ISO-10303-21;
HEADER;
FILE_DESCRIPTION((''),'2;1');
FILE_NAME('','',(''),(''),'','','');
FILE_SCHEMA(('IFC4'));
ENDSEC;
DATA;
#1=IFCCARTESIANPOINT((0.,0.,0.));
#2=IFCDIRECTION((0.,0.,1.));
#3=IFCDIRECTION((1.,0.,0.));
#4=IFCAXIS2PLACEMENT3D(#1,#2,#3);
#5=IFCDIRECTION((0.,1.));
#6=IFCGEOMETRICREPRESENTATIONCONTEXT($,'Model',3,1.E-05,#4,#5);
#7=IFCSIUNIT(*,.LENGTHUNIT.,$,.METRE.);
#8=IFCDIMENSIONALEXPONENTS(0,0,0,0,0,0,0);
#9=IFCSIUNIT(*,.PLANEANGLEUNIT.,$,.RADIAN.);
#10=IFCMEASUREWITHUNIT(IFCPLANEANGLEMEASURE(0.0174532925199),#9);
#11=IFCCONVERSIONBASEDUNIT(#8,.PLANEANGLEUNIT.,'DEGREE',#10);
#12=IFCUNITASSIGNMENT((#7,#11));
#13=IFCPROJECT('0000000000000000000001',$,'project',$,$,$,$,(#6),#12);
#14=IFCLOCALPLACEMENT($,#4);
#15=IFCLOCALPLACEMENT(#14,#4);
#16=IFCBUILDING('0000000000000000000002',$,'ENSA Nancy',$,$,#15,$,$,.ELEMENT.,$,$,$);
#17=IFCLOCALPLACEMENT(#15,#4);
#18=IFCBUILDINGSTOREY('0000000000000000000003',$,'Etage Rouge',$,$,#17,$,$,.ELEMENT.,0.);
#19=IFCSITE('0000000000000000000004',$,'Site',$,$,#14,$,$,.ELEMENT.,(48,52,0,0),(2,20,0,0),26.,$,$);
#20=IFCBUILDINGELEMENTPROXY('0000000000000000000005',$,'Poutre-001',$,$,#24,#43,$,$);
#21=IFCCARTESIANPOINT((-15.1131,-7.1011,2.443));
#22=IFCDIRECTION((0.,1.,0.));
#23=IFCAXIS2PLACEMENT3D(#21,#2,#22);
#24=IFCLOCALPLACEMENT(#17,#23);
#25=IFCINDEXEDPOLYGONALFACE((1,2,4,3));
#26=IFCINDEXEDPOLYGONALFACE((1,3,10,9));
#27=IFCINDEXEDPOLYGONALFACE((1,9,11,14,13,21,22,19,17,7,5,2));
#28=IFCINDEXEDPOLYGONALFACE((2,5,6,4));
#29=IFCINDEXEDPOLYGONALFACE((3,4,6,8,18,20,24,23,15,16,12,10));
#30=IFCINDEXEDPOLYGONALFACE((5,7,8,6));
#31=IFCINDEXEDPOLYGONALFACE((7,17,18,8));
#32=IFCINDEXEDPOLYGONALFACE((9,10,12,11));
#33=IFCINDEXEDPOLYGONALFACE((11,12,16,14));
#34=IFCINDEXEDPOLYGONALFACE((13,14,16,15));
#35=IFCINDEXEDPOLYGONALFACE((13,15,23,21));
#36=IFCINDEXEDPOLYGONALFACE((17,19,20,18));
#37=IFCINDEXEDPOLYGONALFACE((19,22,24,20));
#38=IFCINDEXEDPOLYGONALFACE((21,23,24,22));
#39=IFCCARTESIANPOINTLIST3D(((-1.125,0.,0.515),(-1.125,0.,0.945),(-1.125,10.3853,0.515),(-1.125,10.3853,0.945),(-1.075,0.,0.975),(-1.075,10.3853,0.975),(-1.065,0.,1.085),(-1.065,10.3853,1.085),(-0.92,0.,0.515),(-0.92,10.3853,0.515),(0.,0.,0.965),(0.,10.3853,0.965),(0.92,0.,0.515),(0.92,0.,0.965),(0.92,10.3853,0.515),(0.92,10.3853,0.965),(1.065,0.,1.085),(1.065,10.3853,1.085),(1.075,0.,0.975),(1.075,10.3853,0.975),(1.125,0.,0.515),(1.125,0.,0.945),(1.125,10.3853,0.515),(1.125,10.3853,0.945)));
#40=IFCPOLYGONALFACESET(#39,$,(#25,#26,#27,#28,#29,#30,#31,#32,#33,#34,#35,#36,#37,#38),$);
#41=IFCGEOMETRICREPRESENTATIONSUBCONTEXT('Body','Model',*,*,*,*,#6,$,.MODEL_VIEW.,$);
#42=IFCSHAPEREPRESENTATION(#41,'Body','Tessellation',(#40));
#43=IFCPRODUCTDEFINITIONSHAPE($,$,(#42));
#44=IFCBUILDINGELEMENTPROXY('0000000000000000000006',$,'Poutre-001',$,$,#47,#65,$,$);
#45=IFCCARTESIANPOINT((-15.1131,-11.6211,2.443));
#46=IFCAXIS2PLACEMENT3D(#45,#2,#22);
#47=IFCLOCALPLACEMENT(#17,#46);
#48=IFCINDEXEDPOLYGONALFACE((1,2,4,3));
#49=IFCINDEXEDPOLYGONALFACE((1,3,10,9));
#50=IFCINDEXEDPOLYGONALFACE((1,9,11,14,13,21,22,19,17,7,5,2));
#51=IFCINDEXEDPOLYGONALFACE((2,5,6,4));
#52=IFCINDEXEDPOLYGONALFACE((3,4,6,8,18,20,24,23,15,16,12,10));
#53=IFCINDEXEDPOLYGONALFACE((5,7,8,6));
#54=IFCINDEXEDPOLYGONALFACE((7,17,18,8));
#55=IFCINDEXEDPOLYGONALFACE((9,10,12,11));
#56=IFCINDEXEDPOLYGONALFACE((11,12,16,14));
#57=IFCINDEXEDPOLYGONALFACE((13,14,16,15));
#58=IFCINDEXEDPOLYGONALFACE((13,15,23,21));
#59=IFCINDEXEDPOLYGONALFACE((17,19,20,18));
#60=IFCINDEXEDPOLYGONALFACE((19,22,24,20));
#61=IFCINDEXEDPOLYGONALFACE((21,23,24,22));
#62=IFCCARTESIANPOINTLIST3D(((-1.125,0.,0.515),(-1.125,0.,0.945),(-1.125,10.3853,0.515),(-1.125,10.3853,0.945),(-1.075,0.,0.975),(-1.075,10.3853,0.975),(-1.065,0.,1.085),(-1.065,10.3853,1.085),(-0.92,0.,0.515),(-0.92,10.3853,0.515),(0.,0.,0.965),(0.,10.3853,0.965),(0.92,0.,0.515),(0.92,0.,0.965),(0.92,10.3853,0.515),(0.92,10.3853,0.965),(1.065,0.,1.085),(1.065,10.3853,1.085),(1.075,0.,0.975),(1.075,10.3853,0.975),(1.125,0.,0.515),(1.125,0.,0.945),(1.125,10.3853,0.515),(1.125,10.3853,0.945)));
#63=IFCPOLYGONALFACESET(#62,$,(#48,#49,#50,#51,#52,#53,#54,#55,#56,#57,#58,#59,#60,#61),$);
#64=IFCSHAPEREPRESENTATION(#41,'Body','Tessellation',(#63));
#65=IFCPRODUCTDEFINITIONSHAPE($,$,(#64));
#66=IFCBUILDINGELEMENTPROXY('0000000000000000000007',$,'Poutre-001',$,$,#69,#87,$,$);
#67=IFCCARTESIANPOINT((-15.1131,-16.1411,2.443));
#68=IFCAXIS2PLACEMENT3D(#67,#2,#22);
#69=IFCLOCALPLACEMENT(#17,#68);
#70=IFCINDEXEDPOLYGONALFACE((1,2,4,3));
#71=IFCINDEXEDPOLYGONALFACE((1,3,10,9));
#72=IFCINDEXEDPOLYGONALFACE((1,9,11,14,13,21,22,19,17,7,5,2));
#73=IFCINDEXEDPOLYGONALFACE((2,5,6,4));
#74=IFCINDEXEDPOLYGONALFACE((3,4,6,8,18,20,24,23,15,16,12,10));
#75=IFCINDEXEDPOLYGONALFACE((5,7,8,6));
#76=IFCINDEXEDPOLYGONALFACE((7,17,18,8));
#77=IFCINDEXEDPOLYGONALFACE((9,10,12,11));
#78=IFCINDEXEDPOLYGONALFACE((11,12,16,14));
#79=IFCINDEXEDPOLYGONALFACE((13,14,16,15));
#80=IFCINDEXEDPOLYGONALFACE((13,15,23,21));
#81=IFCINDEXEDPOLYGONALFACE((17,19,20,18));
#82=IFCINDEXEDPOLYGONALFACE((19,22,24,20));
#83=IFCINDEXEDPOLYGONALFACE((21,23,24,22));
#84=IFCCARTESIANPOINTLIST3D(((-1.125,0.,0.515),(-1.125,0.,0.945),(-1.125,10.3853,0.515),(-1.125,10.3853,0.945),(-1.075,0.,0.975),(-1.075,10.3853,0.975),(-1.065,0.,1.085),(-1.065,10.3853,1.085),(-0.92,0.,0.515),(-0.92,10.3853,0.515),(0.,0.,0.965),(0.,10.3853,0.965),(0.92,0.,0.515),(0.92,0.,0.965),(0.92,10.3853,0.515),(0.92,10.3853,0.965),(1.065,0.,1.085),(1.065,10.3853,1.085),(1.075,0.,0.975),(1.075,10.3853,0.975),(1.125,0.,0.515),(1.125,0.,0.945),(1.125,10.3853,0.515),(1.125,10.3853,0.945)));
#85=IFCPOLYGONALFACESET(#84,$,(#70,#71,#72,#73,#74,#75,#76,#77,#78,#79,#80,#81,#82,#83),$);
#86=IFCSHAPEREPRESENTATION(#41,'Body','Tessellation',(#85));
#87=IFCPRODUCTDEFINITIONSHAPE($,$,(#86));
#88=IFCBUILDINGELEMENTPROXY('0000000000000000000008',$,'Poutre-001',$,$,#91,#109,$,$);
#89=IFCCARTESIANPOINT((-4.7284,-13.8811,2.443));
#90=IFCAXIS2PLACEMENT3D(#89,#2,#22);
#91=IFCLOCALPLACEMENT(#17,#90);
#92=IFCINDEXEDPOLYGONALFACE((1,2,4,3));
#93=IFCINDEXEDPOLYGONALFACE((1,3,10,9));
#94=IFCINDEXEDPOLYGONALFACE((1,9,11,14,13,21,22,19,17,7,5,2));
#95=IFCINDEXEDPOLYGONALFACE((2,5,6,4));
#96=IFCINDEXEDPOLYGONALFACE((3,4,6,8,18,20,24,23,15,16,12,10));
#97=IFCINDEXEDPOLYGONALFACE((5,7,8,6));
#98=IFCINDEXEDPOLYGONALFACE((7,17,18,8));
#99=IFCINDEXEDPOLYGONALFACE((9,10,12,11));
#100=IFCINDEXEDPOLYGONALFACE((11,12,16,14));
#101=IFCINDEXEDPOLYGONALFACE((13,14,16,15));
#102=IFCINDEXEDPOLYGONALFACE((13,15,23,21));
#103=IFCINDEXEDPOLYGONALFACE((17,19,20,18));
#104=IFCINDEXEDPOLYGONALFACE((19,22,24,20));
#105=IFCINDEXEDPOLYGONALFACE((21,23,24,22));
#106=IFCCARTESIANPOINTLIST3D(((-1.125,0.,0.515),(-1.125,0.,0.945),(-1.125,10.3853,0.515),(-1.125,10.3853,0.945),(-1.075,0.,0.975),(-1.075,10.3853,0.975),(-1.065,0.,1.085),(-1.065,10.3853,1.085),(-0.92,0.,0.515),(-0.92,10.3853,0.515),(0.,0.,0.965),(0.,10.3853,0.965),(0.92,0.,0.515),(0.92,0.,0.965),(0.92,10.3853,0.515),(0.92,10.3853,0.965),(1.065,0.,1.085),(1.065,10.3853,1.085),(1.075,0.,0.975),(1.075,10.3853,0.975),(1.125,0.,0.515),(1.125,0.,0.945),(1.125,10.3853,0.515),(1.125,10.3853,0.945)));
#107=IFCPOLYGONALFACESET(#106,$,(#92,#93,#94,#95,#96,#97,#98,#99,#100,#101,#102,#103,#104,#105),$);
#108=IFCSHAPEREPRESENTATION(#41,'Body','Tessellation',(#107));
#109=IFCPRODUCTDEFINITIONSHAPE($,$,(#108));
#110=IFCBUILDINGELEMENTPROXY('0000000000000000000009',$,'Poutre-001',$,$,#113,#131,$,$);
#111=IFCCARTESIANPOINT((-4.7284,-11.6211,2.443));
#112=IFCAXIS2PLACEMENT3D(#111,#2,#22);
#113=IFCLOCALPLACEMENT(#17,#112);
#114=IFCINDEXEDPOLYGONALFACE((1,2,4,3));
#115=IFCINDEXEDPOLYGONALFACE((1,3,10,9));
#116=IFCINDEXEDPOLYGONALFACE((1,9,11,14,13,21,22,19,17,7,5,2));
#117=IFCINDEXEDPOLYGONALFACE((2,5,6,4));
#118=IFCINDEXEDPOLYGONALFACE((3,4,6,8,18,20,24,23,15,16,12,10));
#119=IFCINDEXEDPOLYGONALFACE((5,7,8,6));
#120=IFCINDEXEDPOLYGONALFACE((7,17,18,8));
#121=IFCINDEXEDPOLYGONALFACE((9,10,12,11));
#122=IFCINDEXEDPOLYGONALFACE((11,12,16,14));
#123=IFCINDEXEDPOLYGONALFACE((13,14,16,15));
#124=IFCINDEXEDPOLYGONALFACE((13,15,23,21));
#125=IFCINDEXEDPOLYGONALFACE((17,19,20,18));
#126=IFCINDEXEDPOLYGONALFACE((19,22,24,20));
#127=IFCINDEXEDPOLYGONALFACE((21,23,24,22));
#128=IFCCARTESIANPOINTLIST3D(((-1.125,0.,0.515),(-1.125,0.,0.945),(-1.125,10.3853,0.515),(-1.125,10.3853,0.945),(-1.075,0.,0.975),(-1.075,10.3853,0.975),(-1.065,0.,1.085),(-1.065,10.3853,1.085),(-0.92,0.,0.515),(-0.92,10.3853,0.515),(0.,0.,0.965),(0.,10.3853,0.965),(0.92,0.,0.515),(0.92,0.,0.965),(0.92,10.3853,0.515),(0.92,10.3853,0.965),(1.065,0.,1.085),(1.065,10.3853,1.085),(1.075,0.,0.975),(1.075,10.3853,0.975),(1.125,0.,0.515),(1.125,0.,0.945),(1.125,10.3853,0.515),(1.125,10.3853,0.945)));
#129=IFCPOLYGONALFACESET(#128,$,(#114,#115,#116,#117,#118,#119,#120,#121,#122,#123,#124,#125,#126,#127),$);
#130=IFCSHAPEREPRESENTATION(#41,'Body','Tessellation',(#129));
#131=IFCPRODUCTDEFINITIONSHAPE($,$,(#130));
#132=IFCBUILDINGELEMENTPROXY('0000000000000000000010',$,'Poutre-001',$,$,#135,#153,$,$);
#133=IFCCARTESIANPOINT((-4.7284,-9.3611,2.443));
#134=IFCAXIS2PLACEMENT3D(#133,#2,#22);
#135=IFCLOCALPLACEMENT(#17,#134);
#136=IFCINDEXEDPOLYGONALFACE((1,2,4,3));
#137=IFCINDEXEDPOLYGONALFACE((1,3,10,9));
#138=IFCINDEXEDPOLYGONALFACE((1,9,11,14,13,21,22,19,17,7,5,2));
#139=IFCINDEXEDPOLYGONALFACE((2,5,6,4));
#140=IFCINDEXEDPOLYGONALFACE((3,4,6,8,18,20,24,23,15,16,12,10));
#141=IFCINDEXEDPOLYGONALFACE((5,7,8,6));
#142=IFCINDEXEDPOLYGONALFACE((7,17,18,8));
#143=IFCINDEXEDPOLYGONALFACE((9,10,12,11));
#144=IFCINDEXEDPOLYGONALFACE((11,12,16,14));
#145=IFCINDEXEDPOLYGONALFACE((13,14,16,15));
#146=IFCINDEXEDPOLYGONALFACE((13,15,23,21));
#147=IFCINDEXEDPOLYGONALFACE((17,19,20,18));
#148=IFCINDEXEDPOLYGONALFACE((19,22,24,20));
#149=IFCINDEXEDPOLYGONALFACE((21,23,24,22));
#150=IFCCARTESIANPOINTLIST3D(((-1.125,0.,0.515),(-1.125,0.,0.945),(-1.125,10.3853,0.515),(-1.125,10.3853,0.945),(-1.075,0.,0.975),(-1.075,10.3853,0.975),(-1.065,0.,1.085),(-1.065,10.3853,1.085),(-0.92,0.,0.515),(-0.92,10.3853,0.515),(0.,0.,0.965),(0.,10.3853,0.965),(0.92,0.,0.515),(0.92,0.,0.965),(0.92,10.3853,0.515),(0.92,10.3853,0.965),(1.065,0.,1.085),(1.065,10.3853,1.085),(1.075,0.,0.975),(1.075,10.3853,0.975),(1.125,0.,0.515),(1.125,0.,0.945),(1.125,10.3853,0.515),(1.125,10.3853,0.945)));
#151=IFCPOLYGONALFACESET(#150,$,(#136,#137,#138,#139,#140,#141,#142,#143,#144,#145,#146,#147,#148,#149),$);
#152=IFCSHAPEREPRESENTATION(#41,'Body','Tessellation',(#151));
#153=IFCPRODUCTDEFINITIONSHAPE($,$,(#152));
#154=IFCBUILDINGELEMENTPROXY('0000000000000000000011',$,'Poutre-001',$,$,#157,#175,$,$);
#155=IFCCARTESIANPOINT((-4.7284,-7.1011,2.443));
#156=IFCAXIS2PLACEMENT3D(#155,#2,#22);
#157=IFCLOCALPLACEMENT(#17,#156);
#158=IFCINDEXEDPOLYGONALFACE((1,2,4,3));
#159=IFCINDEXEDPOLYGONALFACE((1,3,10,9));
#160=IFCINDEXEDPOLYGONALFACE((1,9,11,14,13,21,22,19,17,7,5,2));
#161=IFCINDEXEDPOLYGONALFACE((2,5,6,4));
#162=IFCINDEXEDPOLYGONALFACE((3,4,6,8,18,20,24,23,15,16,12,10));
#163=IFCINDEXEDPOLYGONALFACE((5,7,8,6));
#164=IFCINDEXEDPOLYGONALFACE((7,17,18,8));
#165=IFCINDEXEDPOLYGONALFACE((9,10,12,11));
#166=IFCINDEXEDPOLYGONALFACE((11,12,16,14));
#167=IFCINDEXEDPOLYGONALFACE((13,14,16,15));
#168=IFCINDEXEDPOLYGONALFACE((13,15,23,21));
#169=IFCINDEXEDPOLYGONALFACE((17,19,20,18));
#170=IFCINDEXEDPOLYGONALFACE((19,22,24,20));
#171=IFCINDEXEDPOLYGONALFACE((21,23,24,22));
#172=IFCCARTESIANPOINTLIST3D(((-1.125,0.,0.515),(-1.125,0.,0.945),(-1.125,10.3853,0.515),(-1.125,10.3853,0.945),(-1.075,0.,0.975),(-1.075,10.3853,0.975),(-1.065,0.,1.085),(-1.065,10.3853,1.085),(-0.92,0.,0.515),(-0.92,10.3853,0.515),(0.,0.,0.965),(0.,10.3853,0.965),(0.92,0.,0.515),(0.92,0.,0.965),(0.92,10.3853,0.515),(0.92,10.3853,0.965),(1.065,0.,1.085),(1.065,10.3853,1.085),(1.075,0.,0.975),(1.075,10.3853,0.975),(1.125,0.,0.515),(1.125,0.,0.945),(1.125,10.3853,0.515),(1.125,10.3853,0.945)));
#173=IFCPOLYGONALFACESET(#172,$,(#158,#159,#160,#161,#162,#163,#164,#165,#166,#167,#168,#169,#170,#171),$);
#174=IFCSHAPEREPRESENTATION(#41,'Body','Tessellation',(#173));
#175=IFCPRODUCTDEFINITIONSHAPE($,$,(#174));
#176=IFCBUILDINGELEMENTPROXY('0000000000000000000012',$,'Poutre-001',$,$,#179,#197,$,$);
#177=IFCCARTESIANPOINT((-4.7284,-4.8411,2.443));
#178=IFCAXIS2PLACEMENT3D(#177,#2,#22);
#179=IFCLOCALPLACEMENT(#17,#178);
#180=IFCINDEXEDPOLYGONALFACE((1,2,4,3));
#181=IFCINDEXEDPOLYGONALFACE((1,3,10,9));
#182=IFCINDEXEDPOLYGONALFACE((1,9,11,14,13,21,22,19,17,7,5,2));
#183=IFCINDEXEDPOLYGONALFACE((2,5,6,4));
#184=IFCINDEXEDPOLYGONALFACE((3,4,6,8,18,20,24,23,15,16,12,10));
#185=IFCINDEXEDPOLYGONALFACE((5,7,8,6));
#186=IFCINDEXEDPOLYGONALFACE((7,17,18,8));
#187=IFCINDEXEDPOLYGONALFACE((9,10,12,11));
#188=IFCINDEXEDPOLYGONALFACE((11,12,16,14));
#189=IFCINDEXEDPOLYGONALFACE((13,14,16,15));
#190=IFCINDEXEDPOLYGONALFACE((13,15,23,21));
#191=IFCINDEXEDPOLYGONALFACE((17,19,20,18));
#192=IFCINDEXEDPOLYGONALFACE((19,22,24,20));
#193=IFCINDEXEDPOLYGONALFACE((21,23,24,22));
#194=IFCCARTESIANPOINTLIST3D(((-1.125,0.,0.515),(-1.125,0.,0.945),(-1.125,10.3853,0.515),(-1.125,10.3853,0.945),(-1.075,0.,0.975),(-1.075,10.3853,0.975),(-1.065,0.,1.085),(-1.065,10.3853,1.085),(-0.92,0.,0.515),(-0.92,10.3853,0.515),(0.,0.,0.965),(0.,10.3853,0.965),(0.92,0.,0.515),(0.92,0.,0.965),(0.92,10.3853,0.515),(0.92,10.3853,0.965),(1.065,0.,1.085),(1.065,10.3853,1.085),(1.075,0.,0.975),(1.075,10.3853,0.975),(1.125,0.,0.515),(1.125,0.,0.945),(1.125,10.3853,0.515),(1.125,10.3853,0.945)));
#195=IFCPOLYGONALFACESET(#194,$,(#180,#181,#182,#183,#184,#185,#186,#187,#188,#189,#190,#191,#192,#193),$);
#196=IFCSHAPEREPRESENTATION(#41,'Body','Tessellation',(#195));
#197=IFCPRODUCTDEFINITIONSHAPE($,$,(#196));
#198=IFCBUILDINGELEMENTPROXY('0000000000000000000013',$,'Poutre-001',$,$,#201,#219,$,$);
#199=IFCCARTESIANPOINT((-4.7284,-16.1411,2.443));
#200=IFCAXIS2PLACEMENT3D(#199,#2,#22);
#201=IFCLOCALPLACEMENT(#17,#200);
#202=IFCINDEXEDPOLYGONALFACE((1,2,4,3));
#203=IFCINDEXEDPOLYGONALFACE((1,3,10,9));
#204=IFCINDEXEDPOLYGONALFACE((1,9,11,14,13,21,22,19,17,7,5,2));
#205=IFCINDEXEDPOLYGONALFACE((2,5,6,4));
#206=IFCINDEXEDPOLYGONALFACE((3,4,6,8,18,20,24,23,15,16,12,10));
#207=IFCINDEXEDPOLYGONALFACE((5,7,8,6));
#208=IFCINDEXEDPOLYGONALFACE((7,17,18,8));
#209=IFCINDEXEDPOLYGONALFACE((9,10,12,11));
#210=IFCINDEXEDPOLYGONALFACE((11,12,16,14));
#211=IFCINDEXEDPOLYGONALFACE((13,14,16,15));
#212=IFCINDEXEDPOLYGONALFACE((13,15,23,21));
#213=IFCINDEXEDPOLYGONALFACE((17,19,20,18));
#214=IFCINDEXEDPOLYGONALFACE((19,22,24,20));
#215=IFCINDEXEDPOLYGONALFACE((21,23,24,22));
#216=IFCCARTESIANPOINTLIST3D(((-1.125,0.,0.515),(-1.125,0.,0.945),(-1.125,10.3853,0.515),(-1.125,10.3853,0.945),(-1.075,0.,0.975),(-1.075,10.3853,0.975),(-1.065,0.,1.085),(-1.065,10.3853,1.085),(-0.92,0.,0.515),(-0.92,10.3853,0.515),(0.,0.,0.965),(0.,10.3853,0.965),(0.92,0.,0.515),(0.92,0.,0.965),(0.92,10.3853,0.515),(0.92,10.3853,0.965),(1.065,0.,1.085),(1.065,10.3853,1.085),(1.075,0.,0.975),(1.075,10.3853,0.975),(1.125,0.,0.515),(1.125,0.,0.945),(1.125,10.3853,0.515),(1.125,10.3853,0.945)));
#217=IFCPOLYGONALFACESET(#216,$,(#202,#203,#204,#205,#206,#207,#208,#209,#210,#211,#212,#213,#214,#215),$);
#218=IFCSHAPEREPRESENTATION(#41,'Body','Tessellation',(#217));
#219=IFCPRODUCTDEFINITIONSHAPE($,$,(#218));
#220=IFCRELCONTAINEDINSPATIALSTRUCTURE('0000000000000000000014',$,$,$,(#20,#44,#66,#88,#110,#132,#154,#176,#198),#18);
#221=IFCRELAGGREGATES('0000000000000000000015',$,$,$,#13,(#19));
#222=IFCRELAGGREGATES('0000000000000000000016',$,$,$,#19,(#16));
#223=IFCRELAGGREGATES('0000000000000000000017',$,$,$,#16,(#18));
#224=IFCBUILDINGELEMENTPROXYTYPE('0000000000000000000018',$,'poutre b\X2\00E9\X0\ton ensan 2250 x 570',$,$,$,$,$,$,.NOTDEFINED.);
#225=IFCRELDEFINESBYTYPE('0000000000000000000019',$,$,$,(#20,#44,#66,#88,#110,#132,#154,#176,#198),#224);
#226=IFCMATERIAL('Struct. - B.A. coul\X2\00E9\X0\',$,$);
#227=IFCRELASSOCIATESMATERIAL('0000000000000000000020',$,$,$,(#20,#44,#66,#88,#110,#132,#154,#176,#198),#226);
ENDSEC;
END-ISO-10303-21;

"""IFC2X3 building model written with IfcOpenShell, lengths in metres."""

from ifc_helpers import new_model, entity, si_unit, converted_unit, direction, frame, origin_with_axes, place, context, subcontext, project, spatial, polyline, outline, extrude, material, type_object, element, save


model = new_model("IFC2X3")

# Units and contexts
model_context = context("Model", 3, precision=1e-05, world=origin_with_axes(), true_north=direction((0.0, 1.0)))
body_context = subcontext(model_context, "Body", "Model", "MODEL_VIEW")
ifc_project = project(units=[si_unit("LENGTHUNIT", "METRE"), converted_unit("PLANEANGLEUNIT", "DEGREE", entity("IfcPlaneAngleMeasure", 0.0174532925199), si_unit("PLANEANGLEUNIT", "RADIAN"), dimensions=[0, 0, 0, 0, 0, 0, 0])], contexts=[model_context])

# Site, building, storey
site_placement = place(None, origin_with_axes())
site = spatial("IfcSite", under=ifc_project, at=site_placement, Name="Site", CompositionType="ELEMENT", RefLatitude=(48, 52, 0, 0), RefLongitude=(2, 20, 0, 0), RefElevation=26.0)
building_placement = place(site_placement, origin_with_axes())
building = spatial("IfcBuilding", under=site, at=building_placement, Name="ENSA Nancy", CompositionType="ELEMENT")
storey_placement = place(building_placement, origin_with_axes())
storey = spatial("IfcBuildingStorey", under=building, at=storey_placement, Name="Etage Rouge", CompositionType="ELEMENT", Elevation=0.0)

# Building element proxies
ifc_material_1 = material(Name="Struct. - B.A. coulé")
building_element_proxy_type_1 = type_object("IfcBuildingElementProxyType", Name="poutre béton ensan 2250 x 570", PredefinedType="NOTDEFINED")
for number, where, z_axis, x_axis, name in (
    (1, (-15.1131, -7.1011, 2.443), (0.0, 0.0, 1.0), (0.0, 1.0, 0.0), "Poutre-001"),
    (2, (-15.1131, -11.6211, 2.443), (0.0, 0.0, 1.0), (0.0, 1.0, 0.0), "Poutre-001"),
    (3, (-15.1131, -16.1411, 2.443), (0.0, 0.0, 1.0), (0.0, 1.0, 0.0), "Poutre-001"),
    (4, (-4.7284, -13.8811, 2.443), (0.0, 0.0, 1.0), (0.0, 1.0, 0.0), "Poutre-001"),
    (5, (-4.7284, -11.6211, 2.443), (0.0, 0.0, 1.0), (0.0, 1.0, 0.0), "Poutre-001"),
    (6, (-4.7284, -9.3611, 2.443), (0.0, 0.0, 1.0), (0.0, 1.0, 0.0), "Poutre-001"),
    (7, (-4.7284, -7.1011, 2.443), (0.0, 0.0, 1.0), (0.0, 1.0, 0.0), "Poutre-001"),
    (8, (-4.7284, -4.8411, 2.443), (0.0, 0.0, 1.0), (0.0, 1.0, 0.0), "Poutre-001"),
    (9, (-4.7284, -16.1411, 2.443), (0.0, 0.0, 1.0), (0.0, 1.0, 0.0), "Poutre-001"),
):
    element("IfcBuildingElementProxy", number, at=place(storey_placement, frame(where, z_axis=z_axis, x_axis=x_axis)), inside=storey, type_object=building_element_proxy_type_1, material=ifc_material_1, Name=name, context=body_context, shape_type="SweptSolid", body=[
        extrude(outline(polyline([(-1.065, 1.085), (-1.075, 0.975), (-1.125, 0.945), (-1.125, 0.515), (-0.92, 0.515), (0.0, 0.965), (0.92, 0.965), (0.92, 0.515), (1.125, 0.515), (1.125, 0.945), (1.075, 0.975), (1.065, 1.085), (-1.065, 1.085)])), frame((0.0, 10.3853, 0.0), z_axis=(0.0, -1.0, 0.0), x_axis=(1.0, 0.0, 0.0)), (0.0, 0.0, 1.0), 10.3853),
    ])

save(model, "model.ifc")
